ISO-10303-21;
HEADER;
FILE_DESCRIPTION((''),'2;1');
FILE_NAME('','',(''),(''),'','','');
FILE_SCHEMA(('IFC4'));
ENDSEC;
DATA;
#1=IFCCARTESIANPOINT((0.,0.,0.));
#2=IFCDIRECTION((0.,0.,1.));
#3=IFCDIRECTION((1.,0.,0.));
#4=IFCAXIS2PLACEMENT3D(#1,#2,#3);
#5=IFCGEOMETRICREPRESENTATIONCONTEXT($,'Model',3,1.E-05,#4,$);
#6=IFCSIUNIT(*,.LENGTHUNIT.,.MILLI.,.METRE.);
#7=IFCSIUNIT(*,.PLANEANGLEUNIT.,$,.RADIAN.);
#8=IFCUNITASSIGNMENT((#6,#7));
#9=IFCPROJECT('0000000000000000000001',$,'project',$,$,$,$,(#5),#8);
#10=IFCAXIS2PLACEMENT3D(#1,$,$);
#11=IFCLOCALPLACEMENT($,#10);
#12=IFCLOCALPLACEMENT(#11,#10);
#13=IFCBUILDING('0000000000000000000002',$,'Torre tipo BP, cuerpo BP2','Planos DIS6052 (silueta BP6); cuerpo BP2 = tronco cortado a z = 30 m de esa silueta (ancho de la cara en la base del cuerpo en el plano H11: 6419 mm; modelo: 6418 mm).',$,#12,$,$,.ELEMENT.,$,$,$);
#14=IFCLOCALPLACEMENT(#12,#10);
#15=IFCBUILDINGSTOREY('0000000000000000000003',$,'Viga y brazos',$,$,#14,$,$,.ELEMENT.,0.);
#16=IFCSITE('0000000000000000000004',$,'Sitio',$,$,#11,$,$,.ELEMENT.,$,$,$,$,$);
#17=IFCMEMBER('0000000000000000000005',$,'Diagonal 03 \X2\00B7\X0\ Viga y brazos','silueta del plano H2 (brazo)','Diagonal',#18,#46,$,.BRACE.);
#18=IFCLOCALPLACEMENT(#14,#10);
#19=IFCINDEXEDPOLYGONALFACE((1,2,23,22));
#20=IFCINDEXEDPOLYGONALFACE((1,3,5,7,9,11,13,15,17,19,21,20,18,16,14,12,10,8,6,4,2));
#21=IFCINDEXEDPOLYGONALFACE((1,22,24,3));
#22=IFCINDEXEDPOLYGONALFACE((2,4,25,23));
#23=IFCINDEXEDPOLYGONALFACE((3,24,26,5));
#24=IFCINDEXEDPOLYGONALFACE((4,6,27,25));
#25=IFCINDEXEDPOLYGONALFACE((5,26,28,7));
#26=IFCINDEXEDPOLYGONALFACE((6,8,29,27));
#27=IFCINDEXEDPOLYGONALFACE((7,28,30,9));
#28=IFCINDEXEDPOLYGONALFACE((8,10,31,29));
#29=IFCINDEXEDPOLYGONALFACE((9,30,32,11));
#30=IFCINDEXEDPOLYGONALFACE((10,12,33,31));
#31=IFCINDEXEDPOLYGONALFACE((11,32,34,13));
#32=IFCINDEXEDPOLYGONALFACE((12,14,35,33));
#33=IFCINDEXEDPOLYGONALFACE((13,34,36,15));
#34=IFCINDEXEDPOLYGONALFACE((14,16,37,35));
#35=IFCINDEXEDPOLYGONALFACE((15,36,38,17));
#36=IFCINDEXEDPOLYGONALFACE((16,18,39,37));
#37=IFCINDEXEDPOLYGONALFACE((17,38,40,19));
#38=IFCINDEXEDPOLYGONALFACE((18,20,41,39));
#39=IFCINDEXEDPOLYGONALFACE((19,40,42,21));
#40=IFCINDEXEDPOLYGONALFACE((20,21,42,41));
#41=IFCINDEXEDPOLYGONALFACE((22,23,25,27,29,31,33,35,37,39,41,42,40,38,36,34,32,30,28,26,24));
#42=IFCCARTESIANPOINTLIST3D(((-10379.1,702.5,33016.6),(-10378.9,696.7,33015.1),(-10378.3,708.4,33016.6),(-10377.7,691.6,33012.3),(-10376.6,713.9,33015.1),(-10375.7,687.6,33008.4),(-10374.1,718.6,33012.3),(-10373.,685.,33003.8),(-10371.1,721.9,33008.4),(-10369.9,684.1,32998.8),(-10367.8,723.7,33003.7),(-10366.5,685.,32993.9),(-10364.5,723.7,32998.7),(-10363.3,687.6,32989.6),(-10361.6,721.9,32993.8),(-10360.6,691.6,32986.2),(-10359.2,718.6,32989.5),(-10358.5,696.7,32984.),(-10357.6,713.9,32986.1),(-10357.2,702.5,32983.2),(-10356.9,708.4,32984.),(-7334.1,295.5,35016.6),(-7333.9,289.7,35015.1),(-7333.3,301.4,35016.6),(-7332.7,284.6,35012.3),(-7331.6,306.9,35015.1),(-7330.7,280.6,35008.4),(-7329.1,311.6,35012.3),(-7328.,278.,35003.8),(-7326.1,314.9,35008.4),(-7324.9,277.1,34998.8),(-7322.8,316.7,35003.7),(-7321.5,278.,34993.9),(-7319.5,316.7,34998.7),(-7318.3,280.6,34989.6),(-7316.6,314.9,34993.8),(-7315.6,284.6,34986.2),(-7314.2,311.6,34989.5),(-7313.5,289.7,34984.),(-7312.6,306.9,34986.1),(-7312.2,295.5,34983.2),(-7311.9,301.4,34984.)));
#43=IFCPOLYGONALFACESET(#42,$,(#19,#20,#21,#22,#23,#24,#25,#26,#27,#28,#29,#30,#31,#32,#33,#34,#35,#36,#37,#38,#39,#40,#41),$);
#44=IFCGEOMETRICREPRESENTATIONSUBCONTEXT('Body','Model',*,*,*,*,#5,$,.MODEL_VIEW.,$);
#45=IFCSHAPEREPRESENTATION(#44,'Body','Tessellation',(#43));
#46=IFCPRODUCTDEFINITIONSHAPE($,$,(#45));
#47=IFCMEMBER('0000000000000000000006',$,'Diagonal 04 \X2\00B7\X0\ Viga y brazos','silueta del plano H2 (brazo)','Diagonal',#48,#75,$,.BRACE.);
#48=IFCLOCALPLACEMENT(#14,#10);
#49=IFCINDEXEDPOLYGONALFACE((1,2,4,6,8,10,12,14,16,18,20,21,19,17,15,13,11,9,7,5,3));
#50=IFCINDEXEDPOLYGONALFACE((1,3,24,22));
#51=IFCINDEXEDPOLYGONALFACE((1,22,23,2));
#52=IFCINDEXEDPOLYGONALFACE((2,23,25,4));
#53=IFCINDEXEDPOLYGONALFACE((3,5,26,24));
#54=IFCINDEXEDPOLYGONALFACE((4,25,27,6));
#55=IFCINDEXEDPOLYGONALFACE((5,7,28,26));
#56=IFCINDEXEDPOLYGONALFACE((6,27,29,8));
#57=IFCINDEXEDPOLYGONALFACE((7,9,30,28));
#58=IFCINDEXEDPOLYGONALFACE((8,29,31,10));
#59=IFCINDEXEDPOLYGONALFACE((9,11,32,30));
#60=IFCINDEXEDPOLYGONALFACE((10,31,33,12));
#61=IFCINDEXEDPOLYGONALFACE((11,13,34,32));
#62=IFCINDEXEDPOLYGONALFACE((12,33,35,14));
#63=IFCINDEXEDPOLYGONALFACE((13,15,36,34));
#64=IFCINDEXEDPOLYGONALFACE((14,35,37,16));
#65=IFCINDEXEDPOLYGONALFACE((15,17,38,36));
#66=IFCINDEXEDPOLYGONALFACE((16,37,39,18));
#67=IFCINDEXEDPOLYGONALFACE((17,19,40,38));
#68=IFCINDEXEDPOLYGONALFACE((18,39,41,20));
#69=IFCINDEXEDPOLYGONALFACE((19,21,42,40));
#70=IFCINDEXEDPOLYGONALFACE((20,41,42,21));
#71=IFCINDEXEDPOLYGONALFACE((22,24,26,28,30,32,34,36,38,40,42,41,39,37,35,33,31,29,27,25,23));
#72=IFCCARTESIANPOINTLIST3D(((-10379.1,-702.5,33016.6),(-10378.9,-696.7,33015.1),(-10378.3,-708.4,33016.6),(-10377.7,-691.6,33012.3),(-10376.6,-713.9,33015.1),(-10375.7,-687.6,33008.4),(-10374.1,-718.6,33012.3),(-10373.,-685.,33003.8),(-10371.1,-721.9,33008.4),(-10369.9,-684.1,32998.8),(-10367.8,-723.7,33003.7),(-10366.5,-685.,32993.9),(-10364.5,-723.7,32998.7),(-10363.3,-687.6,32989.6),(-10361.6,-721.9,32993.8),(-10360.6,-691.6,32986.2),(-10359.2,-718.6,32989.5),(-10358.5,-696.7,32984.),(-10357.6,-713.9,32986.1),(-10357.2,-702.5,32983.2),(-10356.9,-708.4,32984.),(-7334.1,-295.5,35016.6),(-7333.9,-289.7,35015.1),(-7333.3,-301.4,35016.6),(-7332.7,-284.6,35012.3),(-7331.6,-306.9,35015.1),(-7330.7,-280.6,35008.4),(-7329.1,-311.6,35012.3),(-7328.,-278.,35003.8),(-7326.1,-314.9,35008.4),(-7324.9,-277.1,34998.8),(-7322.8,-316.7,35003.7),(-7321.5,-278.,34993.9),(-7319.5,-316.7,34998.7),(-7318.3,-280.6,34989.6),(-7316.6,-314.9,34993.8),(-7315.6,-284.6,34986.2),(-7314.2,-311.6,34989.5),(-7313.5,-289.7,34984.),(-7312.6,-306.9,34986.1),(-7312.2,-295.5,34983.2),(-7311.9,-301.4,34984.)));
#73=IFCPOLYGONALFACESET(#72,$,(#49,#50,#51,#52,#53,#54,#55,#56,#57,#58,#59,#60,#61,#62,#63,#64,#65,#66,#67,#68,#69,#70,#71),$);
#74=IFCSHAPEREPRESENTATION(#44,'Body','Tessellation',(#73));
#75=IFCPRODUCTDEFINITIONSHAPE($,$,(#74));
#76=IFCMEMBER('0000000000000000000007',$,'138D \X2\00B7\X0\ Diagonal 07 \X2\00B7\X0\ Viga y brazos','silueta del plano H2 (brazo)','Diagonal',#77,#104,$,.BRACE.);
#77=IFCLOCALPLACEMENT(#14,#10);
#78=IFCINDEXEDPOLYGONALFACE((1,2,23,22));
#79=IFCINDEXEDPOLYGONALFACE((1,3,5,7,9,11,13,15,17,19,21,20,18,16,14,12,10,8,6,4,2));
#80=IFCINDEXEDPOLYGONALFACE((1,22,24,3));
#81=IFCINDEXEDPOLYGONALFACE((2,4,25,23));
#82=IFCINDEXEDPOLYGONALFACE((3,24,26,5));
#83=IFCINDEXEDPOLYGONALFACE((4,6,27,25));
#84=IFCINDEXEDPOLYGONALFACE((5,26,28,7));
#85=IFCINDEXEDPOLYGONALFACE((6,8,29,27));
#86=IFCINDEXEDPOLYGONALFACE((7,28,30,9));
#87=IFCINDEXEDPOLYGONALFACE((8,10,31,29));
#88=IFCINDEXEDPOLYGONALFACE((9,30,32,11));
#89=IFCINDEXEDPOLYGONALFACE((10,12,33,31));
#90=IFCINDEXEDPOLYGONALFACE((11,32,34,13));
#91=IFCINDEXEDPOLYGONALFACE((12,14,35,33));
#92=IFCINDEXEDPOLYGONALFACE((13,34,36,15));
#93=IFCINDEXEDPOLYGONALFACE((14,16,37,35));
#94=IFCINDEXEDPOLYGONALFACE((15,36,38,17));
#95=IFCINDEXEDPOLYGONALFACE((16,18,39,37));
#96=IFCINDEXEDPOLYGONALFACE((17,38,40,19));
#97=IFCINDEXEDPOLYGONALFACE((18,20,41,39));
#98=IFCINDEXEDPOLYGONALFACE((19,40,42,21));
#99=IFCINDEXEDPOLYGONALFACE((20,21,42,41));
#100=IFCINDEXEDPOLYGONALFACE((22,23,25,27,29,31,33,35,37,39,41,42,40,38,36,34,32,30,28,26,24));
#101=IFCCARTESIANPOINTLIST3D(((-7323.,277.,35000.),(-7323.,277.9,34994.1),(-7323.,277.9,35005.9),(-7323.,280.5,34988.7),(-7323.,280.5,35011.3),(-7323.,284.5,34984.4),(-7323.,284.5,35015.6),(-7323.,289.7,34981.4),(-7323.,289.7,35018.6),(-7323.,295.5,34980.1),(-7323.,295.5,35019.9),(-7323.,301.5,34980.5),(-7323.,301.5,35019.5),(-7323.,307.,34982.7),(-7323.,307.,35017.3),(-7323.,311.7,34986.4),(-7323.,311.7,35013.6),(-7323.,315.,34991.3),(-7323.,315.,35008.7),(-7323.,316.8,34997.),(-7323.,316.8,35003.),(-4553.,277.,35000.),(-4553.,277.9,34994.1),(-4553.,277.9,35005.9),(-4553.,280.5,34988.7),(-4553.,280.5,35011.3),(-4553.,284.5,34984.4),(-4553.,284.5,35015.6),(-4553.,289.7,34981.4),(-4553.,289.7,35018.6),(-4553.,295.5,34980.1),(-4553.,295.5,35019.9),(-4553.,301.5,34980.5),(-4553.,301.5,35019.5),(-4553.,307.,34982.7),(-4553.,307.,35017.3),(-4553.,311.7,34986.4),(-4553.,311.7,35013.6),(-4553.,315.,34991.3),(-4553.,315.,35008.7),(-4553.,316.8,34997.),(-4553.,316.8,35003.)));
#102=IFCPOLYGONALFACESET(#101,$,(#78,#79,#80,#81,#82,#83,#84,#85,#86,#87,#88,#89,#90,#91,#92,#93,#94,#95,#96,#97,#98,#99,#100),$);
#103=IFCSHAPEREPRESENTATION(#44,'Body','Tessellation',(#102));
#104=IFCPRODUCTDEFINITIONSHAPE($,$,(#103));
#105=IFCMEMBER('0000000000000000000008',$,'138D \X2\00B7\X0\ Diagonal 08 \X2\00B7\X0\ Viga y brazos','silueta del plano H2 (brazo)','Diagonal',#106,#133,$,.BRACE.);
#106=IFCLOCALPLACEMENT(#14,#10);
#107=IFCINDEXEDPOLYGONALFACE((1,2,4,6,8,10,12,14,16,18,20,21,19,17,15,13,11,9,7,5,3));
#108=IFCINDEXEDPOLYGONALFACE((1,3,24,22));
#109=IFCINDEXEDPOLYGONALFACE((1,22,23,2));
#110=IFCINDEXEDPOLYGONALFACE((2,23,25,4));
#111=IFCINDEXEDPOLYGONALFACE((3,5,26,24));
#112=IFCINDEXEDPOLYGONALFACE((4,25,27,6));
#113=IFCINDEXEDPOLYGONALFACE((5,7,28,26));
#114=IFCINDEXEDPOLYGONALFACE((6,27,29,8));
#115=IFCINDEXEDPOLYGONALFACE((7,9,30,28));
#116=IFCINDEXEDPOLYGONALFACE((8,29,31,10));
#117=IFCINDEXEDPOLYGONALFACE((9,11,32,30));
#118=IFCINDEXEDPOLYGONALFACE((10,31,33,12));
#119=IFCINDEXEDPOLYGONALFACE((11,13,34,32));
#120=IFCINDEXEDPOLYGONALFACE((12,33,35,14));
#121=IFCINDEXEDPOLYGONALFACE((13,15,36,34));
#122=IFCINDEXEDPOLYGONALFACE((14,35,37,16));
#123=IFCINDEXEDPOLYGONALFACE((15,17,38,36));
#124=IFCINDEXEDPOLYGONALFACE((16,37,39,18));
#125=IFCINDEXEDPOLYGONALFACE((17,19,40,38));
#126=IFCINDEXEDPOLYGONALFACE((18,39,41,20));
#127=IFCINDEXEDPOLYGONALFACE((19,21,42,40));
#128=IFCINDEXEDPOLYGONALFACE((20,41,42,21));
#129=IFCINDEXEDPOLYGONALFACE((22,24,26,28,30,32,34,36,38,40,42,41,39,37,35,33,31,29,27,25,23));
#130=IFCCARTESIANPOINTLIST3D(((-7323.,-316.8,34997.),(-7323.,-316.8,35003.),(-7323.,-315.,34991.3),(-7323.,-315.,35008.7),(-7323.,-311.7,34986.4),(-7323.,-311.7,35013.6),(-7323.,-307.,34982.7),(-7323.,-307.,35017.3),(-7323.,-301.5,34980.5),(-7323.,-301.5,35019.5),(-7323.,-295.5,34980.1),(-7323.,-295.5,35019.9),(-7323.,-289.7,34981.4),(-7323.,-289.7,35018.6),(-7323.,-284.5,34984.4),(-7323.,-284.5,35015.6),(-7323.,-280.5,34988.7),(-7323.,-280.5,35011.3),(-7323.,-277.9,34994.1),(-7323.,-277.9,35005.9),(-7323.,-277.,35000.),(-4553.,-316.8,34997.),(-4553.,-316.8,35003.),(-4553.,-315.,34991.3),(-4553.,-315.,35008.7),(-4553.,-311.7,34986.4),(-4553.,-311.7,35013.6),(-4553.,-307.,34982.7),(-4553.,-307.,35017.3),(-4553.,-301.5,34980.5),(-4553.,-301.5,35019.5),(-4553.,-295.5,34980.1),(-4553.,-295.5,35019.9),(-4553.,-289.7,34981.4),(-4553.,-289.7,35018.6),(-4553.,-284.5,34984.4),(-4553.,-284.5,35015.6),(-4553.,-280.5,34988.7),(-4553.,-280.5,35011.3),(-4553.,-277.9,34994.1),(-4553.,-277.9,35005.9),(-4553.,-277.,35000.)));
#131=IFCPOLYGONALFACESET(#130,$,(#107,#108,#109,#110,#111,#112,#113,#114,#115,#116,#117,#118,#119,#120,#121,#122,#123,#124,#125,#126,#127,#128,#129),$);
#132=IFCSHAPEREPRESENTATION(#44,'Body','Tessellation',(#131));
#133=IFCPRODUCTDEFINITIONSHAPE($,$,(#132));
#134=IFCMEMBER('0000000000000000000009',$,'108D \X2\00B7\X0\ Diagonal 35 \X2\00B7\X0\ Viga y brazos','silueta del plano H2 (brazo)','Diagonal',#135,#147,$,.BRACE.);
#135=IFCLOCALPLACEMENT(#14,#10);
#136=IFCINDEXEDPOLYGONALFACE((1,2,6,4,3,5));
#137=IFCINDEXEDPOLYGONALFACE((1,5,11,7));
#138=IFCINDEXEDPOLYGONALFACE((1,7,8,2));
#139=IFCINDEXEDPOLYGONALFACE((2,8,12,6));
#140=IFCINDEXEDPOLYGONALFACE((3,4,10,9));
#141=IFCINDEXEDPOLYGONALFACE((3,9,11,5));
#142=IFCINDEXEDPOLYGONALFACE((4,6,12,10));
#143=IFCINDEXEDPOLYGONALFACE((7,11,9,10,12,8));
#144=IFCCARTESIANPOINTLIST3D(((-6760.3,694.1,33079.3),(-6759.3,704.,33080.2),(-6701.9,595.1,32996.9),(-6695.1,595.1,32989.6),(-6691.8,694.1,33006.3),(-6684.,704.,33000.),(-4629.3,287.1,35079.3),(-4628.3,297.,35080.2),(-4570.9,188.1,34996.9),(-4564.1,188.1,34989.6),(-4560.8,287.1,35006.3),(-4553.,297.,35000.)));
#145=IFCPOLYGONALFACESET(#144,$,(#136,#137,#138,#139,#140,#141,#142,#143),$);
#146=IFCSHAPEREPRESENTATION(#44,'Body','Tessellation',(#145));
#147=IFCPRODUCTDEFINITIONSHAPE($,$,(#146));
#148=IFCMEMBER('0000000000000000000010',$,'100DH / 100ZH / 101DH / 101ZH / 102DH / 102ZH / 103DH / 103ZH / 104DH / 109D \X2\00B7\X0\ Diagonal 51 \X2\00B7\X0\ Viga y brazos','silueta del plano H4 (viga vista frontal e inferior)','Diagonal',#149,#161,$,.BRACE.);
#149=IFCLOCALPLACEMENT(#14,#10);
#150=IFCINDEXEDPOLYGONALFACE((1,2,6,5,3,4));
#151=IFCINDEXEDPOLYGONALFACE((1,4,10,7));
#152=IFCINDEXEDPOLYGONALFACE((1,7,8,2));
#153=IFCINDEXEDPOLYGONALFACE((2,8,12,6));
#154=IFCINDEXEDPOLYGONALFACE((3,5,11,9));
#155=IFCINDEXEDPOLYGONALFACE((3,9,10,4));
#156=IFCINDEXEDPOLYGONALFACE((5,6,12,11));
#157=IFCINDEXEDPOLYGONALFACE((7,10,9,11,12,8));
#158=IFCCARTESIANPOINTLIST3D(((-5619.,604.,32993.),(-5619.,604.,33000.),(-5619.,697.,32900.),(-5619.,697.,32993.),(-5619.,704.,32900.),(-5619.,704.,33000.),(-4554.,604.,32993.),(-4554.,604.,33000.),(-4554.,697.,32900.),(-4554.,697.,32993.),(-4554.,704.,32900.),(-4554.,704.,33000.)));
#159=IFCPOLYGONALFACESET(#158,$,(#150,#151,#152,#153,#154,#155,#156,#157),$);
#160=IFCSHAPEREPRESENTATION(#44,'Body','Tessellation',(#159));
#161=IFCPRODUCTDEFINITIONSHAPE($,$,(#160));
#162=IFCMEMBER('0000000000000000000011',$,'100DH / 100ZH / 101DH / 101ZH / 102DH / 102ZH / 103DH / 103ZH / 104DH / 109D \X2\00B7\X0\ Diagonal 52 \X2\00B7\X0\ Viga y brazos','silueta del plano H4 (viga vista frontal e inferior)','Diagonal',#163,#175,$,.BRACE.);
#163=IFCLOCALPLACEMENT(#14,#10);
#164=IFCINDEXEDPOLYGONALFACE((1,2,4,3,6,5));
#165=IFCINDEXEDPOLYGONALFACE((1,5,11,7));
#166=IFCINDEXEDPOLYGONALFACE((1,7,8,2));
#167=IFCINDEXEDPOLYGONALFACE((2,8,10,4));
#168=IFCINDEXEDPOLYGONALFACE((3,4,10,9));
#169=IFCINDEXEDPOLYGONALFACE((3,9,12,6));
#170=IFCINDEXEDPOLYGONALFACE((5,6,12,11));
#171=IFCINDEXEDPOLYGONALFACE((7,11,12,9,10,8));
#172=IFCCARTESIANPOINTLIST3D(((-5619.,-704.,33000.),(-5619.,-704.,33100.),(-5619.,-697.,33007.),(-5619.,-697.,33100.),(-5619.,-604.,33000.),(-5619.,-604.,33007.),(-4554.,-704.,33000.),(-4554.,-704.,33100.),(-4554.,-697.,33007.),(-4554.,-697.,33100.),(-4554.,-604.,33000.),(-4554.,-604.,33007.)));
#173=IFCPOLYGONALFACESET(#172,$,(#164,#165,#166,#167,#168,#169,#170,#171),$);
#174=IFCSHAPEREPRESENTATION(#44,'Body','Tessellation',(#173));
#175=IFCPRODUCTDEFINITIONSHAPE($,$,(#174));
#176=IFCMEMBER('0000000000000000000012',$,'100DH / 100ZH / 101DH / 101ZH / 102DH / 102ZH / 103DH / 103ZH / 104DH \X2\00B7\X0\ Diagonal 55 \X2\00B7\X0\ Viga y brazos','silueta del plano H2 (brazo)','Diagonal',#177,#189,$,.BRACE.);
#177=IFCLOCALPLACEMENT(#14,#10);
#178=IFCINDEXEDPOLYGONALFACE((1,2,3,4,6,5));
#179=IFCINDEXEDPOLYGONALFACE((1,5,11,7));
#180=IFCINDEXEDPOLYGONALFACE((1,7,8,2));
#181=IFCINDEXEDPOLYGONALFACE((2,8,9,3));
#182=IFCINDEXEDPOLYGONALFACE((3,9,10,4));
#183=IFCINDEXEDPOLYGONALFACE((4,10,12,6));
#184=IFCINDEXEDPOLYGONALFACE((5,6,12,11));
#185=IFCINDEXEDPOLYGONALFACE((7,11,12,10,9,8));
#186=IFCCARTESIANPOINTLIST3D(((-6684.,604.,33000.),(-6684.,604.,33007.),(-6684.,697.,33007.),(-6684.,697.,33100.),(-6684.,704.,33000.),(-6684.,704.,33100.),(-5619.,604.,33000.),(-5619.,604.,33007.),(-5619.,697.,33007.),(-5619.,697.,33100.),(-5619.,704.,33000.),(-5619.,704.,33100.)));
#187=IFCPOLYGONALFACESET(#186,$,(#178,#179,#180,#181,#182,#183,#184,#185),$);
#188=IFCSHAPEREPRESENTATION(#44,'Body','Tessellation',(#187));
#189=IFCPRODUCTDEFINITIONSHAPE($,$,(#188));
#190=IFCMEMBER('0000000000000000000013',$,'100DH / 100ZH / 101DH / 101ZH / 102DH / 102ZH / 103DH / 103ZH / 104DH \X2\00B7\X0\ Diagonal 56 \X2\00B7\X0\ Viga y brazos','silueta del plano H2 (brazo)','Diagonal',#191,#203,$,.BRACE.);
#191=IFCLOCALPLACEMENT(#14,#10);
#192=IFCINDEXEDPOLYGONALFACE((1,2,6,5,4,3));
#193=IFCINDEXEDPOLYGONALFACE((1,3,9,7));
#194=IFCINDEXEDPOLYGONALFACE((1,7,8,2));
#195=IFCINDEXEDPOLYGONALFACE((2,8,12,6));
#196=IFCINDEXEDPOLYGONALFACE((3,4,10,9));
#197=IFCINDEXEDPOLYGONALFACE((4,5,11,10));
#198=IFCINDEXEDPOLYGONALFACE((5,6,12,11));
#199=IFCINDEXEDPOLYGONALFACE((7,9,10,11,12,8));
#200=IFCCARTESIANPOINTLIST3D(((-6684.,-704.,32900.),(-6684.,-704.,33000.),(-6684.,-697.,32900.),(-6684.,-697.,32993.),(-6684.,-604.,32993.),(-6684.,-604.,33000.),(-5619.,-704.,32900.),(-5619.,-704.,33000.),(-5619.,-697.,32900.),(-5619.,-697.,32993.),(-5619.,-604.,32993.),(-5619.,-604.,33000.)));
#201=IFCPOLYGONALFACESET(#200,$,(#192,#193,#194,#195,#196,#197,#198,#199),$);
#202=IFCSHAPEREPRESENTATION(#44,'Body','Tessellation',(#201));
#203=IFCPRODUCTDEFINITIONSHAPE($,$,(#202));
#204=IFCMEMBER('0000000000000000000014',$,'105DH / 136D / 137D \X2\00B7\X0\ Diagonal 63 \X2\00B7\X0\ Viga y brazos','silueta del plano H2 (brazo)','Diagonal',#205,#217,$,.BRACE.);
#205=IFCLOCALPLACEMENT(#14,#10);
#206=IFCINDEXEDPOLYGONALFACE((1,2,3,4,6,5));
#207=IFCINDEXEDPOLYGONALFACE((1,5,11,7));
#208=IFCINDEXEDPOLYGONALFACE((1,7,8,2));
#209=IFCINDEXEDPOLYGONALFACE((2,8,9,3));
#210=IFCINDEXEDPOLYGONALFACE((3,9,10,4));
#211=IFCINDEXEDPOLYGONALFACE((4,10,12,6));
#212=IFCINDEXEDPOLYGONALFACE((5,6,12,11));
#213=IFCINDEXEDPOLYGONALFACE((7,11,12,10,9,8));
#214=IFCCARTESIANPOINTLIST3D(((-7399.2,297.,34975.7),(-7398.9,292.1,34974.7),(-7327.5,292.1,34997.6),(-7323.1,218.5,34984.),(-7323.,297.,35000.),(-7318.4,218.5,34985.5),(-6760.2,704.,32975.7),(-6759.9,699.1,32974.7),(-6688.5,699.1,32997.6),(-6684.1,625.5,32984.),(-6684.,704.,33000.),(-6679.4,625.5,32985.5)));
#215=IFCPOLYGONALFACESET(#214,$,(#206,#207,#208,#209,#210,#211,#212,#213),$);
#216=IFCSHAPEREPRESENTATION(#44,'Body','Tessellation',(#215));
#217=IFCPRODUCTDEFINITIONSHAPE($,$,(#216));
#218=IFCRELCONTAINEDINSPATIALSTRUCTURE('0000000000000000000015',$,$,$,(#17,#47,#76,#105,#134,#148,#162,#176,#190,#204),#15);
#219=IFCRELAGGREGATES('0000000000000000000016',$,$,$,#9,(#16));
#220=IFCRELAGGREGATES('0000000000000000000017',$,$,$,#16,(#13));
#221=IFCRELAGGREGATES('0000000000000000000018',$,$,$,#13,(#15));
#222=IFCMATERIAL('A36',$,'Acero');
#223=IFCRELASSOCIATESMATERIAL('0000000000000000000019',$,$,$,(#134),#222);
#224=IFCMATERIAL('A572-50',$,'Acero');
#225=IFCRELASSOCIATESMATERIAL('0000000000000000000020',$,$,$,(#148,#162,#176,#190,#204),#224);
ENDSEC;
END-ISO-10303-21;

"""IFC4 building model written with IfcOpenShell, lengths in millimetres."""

from ifc_helpers import new_model, si_unit, frame, frame_2d, origin, origin_with_axes, place, context, subcontext, project, spatial, circle, l_section, extrude, material, element, save


model = new_model("IFC4")

# Units and contexts
model_context = context("Model", 3, precision=1e-05, world=origin_with_axes())
body_context = subcontext(model_context, "Body", "Model", "MODEL_VIEW")
ifc_project = project(units=[si_unit("LENGTHUNIT", "METRE", prefix="MILLI"), si_unit("PLANEANGLEUNIT", "RADIAN")], contexts=[model_context])

# Site, building, storey
site_placement = place(None, origin())
site = spatial("IfcSite", under=ifc_project, at=site_placement, Name="Sitio", CompositionType="ELEMENT")
building_placement = place(site_placement, origin())
building = spatial("IfcBuilding", under=site, at=building_placement, Name="Torre tipo BP, cuerpo BP2", Description="Planos DIS6052 (silueta BP6); cuerpo BP2 = tronco cortado a z = 30 m de esa silueta (ancho de la cara en la base del cuerpo en el plano H11: 6419 mm; modelo: 6418 mm).", CompositionType="ELEMENT")
storey_placement = place(building_placement, origin())
storey = spatial("IfcBuildingStorey", under=building, at=storey_placement, Name="Viga y brazos", CompositionType="ELEMENT", Elevation=0.0)

# Members
for number, where, z_axis, x_axis, name in (
    (1, (-7323.0, 297.0, 35000.0), (-0.830664, 0.111028, -0.545592), (-0.092801, -0.993817, -0.060953), "Diagonal 03 · Viga y brazos"),
    (2, (-7323.0, -297.0, 35000.0), (-0.830664, -0.111028, -0.545592), (-0.092801, 0.993817, -0.060953), "Diagonal 04 · Viga y brazos"),
):
    element("IfcMember", number, at=place(storey_placement, frame(where, z_axis=z_axis, x_axis=x_axis)), inside=storey, Name=name, Description="silueta del plano H2 (brazo)", ObjectType="Diagonal", PredefinedType="BRACE", context=body_context, shape_type="SweptSolid", body=[
        extrude(circle(Radius=20.0), None, (0.0, 0.0, 1.0), 3665.7),
    ])
for number, where, z_axis, x_axis, name in (
    (3, (-7323.0, 297.0, 35000.0), (1.0, 0.0, 0.0), (0.0, -1.0, 0.0), "138D · Diagonal 07 · Viga y brazos"),
    (4, (-7323.0, -297.0, 35000.0), (1.0, 0.0, 0.0), (0.0, 1.0, 0.0), "138D · Diagonal 08 · Viga y brazos"),
):
    element("IfcMember", number, at=place(storey_placement, frame(where, z_axis=z_axis, x_axis=x_axis)), inside=storey, Name=name, Description="silueta del plano H2 (brazo)", ObjectType="Diagonal", PredefinedType="BRACE", context=body_context, shape_type="SweptSolid", body=[
        extrude(circle(Radius=20.0), None, (0.0, 0.0, 1.0), 2770.0),
    ])
ifc_material_1 = material(Name="A36", Category="Acero")
member_1_placement = place(storey_placement, frame((-4553.0, 297.0, 35000.0), z_axis=(-0.722194, 0.137932, -0.677798), x_axis=(-0.100575, -0.990442, -0.094392)))
element("IfcMember", 5, at=member_1_placement, inside=storey, material=ifc_material_1, Name="108D · Diagonal 35 · Viga y brazos", Description="silueta del plano H2 (brazo)", ObjectType="Diagonal", PredefinedType="BRACE", context=body_context, shape_type="SweptSolid", body=[
    extrude(l_section(Depth=110.0, Width=110.0, Thickness=10.0, at=frame_2d((55.0, 55.0))), None, (0.0, 0.0, 1.0), 2950.7),
])
ifc_material_2 = material(Name="A572-50", Category="Acero")
for number, where, z_axis, x_axis, name, description in (
    (6, (-5619.0, 704.0, 33000.0), (1.0, 0.0, 0.0), (0.0, -1.0, 0.0), "100DH / 100ZH / 101DH / 101ZH / 102DH / 102ZH / 103DH / 103ZH / 104DH / 109D · Diagonal 51 · Viga y brazos", "silueta del plano H4 (viga vista frontal e inferior)"),
    (7, (-5619.0, -704.0, 33000.0), (1.0, 0.0, 0.0), (0.0, 1.0, 0.0), "100DH / 100ZH / 101DH / 101ZH / 102DH / 102ZH / 103DH / 103ZH / 104DH / 109D · Diagonal 52 · Viga y brazos", "silueta del plano H4 (viga vista frontal e inferior)"),
    (8, (-5619.0, 704.0, 33000.0), (-1.0, 0.0, 0.0), (0.0, -1.0, 0.0), "100DH / 100ZH / 101DH / 101ZH / 102DH / 102ZH / 103DH / 103ZH / 104DH · Diagonal 55 · Viga y brazos", "silueta del plano H2 (brazo)"),
    (9, (-5619.0, -704.0, 33000.0), (-1.0, 0.0, 0.0), (0.0, 1.0, 0.0), "100DH / 100ZH / 101DH / 101ZH / 102DH / 102ZH / 103DH / 103ZH / 104DH · Diagonal 56 · Viga y brazos", "silueta del plano H2 (brazo)"),
):
    element("IfcMember", number, at=place(storey_placement, frame(where, z_axis=z_axis, x_axis=x_axis)), inside=storey, material=ifc_material_2, Name=name, Description=description, ObjectType="Diagonal", PredefinedType="BRACE", context=body_context, shape_type="SweptSolid", body=[
        extrude(l_section(Depth=100.0, Width=100.0, Thickness=7.0, at=frame_2d((50.0, 50.0))), None, (0.0, 0.0, 1.0), 1065.0),
    ])
for number, where, z_axis, x_axis, name in (
    (10, (-7323.0, 297.0, 35000.0), (0.298782, 0.190304, -0.935154), (0.057918, -0.981725, -0.181276), "105DH / 136D / 137D · Diagonal 63 · Viga y brazos"),
):
    element("IfcMember", number, at=place(storey_placement, frame(where, z_axis=z_axis, x_axis=x_axis)), inside=storey, material=ifc_material_2, Name=name, Description="silueta del plano H2 (brazo)", ObjectType="Diagonal", PredefinedType="BRACE", context=body_context, shape_type="SweptSolid", body=[
        extrude(l_section(Depth=80.0, Width=80.0, Thickness=5.0, at=frame_2d((40.0, 40.0))), None, (0.0, 0.0, 1.0), 2138.7),
    ])

save(model, "model.ifc")
